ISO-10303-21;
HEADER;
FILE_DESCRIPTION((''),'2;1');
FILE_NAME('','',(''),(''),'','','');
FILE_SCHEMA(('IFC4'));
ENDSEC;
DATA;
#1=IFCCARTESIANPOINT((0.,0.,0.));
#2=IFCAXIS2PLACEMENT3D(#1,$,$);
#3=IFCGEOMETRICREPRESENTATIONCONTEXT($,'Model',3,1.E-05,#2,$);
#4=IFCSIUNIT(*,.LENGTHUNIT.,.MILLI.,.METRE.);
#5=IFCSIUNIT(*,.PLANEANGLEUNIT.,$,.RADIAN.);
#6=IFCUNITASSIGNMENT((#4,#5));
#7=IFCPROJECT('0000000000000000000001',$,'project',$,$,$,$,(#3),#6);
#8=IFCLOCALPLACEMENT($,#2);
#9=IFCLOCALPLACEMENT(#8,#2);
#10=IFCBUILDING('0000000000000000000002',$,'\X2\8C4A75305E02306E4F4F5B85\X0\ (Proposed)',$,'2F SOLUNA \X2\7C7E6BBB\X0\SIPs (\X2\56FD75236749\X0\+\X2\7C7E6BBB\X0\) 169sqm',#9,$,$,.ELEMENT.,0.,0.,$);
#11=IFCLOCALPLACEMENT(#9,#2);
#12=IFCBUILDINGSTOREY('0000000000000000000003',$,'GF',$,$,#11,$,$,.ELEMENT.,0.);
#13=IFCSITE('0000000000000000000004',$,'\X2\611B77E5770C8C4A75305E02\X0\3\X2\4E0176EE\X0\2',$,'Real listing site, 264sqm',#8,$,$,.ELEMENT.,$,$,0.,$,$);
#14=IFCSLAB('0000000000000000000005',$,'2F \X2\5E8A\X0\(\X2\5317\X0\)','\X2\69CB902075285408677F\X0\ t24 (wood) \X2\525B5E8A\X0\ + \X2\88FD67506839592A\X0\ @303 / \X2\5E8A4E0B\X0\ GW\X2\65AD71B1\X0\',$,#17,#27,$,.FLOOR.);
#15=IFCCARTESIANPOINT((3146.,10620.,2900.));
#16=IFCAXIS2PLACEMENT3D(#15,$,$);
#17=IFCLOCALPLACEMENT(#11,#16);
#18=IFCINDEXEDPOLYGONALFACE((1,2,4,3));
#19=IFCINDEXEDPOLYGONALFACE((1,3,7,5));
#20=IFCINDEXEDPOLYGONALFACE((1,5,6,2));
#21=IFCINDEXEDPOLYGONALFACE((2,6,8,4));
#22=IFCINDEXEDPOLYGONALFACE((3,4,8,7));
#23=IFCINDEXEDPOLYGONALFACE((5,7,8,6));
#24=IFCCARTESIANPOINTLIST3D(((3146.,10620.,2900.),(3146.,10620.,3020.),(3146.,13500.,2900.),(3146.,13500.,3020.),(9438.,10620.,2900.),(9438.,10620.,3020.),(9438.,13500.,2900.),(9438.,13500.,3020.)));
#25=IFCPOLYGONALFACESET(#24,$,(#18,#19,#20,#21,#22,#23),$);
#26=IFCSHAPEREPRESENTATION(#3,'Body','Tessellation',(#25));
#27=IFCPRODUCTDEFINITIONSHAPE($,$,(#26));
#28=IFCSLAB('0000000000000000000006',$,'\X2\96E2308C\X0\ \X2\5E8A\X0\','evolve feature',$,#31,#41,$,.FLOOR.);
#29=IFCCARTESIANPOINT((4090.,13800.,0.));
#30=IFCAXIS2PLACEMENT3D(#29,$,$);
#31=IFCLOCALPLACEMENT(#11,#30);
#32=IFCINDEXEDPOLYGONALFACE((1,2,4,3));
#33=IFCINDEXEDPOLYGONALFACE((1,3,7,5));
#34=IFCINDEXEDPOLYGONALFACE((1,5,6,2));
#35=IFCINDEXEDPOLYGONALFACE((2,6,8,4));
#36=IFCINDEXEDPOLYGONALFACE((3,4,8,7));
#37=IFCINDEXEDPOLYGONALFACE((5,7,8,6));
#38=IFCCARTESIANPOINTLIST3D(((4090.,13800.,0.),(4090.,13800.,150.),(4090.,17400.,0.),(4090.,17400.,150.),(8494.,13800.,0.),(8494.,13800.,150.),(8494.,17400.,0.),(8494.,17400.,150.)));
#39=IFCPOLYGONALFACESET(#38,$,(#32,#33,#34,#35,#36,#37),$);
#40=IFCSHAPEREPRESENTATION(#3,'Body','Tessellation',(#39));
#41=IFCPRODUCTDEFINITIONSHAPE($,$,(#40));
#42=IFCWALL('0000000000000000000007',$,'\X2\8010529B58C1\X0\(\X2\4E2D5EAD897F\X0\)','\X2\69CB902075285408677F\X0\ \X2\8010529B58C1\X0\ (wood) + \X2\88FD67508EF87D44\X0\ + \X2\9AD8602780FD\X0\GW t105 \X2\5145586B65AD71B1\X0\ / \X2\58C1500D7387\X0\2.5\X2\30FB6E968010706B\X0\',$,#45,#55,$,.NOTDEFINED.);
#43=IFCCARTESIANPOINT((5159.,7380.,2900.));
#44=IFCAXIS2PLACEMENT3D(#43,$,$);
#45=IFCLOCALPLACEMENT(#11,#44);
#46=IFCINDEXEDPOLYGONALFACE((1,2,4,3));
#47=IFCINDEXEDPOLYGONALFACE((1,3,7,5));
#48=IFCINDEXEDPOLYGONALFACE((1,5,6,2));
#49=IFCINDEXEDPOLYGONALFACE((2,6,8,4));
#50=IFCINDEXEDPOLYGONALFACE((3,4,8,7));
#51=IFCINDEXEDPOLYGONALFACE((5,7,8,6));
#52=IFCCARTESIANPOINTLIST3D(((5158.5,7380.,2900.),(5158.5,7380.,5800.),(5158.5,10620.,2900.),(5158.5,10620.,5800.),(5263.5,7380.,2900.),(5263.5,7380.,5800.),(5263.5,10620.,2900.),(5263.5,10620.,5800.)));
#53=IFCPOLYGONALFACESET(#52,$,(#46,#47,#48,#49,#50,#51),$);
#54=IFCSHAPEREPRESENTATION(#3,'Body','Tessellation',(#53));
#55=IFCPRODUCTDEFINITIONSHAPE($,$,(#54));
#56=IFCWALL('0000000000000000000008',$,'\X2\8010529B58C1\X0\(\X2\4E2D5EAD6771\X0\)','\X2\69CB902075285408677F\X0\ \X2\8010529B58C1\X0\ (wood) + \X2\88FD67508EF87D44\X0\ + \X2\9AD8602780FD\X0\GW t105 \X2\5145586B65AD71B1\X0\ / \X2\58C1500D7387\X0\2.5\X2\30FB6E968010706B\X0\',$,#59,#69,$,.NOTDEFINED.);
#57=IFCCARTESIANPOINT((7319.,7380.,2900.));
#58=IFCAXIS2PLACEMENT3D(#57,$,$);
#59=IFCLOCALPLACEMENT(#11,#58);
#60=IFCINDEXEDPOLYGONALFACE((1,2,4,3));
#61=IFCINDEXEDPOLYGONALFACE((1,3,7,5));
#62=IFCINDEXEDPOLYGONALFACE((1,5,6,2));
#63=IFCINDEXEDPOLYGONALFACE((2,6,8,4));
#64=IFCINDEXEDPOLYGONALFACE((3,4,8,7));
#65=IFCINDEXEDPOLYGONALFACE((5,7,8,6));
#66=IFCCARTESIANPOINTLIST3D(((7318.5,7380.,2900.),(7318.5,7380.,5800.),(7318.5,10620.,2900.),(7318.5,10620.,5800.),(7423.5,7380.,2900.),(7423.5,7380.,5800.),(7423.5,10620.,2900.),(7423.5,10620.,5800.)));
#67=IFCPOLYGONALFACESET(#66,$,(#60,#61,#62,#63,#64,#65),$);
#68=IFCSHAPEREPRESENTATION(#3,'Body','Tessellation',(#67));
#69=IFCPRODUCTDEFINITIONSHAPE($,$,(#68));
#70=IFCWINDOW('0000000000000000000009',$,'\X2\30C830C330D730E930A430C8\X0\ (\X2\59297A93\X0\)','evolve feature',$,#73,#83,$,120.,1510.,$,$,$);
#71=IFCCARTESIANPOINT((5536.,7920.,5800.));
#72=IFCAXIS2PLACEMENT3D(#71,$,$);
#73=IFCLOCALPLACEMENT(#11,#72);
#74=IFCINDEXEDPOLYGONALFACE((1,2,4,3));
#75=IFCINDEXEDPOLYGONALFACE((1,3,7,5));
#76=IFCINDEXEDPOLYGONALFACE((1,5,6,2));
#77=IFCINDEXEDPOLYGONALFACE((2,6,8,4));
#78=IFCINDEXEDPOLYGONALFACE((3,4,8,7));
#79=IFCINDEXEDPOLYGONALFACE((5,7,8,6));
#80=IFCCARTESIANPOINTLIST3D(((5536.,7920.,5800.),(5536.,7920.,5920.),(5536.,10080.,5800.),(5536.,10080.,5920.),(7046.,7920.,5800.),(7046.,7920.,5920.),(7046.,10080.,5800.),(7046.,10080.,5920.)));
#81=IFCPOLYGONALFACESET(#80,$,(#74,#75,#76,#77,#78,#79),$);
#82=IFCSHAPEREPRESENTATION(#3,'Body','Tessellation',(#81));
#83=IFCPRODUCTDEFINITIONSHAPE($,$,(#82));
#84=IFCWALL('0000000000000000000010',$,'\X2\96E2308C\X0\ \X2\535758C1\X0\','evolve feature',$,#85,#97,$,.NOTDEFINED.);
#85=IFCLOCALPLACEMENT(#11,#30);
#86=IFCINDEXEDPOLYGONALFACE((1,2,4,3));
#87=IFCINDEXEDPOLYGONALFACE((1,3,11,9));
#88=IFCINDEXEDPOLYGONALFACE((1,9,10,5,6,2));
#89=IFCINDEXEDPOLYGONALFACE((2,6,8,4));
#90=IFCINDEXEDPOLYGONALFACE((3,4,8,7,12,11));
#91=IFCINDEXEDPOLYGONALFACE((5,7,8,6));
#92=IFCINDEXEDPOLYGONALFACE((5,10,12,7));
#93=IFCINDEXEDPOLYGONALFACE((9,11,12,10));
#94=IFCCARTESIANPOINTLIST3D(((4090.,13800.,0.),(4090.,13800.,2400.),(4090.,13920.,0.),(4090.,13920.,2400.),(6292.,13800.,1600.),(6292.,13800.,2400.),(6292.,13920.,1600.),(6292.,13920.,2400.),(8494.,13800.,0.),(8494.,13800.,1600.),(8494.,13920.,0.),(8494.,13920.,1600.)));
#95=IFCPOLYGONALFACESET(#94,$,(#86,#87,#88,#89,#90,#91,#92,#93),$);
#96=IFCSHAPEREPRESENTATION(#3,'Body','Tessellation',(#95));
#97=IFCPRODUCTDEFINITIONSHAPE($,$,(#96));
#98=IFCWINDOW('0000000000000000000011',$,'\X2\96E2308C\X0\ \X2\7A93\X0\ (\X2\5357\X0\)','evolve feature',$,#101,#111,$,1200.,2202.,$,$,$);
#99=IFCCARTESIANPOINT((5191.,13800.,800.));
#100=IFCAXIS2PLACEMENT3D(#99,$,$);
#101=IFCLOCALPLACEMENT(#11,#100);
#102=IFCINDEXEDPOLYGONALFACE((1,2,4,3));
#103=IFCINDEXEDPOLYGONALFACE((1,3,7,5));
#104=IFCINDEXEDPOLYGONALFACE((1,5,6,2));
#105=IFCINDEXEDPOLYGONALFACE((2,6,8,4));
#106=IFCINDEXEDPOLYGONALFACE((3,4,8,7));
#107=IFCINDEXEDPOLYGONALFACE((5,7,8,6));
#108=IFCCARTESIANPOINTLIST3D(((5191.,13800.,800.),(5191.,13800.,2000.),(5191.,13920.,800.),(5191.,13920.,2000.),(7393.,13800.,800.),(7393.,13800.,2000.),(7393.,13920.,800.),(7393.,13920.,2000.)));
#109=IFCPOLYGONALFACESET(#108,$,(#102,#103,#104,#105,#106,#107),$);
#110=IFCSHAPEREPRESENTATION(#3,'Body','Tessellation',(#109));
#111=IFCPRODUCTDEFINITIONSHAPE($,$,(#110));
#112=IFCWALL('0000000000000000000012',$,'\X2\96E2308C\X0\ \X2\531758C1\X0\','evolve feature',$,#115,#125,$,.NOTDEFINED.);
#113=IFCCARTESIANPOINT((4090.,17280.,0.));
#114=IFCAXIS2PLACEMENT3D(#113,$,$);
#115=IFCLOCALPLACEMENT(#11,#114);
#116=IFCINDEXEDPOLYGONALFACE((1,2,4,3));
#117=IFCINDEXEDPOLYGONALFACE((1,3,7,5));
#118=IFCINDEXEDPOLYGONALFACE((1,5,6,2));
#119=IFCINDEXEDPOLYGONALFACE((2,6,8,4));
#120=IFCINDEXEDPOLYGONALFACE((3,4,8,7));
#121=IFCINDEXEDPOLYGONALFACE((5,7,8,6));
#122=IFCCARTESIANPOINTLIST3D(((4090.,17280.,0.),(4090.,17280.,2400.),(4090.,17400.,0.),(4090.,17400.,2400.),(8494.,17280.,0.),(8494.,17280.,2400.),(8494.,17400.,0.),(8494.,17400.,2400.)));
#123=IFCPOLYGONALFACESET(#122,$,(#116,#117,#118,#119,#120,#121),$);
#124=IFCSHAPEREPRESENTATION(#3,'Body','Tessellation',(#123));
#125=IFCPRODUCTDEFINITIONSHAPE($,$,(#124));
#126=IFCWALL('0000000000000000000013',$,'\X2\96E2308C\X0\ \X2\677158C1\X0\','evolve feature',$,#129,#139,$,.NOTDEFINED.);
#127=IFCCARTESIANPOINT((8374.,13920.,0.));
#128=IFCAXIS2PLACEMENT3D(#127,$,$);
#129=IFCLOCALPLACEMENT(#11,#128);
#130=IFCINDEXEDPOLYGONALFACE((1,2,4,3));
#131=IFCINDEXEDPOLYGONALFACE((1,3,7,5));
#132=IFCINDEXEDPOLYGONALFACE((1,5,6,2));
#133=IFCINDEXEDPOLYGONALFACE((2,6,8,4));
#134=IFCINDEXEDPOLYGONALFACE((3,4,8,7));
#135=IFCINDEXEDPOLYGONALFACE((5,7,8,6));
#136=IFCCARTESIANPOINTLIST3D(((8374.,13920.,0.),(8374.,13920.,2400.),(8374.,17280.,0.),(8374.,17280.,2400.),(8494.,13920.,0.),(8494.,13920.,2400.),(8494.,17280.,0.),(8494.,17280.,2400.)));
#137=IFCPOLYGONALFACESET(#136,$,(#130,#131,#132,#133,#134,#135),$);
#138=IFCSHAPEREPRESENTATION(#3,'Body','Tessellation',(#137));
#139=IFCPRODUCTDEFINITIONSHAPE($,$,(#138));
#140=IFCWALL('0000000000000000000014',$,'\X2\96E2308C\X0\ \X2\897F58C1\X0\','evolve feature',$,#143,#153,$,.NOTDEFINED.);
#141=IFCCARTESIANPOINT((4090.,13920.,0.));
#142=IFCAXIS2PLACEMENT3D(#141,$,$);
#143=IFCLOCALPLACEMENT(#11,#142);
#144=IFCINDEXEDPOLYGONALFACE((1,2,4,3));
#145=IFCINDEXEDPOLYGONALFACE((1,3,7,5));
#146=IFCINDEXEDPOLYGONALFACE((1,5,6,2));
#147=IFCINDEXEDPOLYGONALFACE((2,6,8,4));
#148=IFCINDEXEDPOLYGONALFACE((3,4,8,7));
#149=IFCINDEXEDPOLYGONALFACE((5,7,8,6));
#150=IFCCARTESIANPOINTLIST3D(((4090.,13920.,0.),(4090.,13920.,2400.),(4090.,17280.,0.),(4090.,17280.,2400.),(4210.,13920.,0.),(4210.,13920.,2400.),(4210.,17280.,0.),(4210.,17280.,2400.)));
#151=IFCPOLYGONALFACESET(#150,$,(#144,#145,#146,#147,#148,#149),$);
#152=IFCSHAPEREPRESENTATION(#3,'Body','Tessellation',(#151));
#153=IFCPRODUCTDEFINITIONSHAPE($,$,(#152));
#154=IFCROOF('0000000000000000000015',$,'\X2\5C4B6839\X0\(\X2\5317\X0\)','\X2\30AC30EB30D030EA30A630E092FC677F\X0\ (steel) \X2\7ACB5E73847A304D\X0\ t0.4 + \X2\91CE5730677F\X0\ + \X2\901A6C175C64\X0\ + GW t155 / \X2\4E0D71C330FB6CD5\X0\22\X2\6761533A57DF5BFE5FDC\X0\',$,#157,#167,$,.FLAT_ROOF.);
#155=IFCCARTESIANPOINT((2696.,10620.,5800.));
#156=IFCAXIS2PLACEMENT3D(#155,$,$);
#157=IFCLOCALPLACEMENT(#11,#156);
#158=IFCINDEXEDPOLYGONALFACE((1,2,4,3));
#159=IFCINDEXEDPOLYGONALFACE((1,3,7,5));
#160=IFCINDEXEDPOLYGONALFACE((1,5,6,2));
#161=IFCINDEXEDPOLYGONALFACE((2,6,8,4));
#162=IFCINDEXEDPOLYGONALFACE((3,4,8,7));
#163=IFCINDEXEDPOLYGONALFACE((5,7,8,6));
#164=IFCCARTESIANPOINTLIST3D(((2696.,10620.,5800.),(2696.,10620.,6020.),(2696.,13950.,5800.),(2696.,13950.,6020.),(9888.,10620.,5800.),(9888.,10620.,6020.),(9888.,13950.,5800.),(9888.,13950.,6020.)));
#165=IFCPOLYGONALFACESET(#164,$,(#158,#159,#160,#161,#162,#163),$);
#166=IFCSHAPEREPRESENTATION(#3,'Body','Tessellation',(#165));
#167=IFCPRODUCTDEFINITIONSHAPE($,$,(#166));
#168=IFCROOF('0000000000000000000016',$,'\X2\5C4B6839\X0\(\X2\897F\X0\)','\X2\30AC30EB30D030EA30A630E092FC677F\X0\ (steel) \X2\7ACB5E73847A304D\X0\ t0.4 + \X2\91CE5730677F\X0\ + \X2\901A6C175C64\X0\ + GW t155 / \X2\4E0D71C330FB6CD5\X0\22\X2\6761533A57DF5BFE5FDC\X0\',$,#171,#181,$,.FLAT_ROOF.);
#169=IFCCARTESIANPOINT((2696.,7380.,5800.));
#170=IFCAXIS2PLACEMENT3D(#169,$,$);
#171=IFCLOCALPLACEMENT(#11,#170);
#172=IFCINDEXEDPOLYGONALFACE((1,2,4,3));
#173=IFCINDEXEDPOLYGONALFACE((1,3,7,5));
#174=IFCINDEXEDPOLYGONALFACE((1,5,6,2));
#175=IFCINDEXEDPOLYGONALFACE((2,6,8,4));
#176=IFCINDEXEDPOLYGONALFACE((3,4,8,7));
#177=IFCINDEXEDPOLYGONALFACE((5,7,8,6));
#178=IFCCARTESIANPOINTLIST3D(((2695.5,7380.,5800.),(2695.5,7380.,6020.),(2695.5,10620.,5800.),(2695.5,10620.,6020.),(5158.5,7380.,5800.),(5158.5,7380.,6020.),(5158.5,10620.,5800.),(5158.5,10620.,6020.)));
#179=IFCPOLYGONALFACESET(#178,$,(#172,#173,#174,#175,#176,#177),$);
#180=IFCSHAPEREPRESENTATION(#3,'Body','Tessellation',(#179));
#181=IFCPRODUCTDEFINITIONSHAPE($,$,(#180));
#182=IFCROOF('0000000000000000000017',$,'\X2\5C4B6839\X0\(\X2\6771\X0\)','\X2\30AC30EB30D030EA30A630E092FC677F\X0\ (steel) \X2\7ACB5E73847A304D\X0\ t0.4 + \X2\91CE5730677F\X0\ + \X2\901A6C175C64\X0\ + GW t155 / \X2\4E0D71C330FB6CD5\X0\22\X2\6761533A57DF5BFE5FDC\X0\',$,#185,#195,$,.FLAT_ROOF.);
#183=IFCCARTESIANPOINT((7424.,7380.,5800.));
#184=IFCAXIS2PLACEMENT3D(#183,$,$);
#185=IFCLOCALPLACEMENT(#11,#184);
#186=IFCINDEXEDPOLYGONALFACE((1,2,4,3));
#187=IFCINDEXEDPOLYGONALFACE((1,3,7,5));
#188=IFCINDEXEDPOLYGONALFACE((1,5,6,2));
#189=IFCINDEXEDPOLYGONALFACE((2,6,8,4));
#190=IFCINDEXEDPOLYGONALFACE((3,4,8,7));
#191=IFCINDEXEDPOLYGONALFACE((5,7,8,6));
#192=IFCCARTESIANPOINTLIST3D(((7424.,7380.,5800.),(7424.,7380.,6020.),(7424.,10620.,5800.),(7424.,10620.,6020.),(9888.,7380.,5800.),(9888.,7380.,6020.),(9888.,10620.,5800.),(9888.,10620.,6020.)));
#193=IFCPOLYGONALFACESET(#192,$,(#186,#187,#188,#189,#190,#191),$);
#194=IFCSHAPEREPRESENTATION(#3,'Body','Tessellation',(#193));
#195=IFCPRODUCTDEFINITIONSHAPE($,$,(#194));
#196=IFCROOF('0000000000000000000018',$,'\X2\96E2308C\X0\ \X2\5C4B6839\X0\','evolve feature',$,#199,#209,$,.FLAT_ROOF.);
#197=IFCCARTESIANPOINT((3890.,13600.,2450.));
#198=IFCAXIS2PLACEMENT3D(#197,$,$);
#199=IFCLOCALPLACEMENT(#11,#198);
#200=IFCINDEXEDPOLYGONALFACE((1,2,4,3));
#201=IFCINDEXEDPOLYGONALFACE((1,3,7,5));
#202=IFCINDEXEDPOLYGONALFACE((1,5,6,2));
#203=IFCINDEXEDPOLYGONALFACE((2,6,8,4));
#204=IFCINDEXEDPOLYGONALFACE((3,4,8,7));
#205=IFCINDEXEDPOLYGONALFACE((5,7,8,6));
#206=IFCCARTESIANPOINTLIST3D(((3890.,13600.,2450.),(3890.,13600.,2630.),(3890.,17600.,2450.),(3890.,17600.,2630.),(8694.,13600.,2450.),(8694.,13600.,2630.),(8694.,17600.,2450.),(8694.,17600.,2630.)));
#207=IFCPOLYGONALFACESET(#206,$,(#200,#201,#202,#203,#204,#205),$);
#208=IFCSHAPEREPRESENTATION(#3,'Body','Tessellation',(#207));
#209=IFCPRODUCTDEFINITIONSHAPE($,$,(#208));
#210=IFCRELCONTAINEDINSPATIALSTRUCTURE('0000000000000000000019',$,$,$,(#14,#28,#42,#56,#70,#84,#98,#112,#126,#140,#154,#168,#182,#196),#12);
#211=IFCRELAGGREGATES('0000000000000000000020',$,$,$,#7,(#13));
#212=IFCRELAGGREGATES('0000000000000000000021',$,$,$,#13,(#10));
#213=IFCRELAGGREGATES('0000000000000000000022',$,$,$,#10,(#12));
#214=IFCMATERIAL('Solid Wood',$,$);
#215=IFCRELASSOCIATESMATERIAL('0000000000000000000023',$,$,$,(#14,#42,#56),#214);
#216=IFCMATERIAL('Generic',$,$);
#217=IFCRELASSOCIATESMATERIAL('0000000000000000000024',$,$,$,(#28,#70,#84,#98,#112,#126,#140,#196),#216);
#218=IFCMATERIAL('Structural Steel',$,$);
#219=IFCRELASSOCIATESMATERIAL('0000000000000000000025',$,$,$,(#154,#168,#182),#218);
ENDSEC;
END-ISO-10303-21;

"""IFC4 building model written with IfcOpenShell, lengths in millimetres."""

from ifc_helpers import new_model, si_unit, frame, frame_2d, origin, place, context, project, spatial, rectangle, extrude, material, element, fill, save


model = new_model("IFC4")

# Units and contexts
model_context = context("Model", 3, precision=1e-05, world=origin())
ifc_project = project(units=[si_unit("LENGTHUNIT", "METRE", prefix="MILLI"), si_unit("PLANEANGLEUNIT", "RADIAN")], contexts=[model_context])

# Site, building, storey
site_placement = place(None, origin())
site = spatial("IfcSite", under=ifc_project, at=site_placement, Name="愛知県豊田市3丁目2", ObjectType="Real listing site, 264sqm", CompositionType="ELEMENT", RefElevation=0.0)
building_placement = place(site_placement, origin())
building = spatial("IfcBuilding", under=site, at=building_placement, Name="豊田市の住宅 (Proposed)", ObjectType="2F SOLUNA 籾殻SIPs (国産杉+籾殻) 169sqm", CompositionType="ELEMENT", ElevationOfRefHeight=0.0, ElevationOfTerrain=0.0)
storey_placement = place(building_placement, origin())
storey = spatial("IfcBuildingStorey", under=building, at=storey_placement, Name="GF", CompositionType="ELEMENT", Elevation=0.0)

# Slabs
ifc_material_1 = material(Name="Solid Wood")
slab_1_placement = place(storey_placement, frame((3146.0, 10620.0, 2900.0)))
element("IfcSlab", 1, at=slab_1_placement, inside=storey, material=ifc_material_1, Name="2F 床(北)", Description="構造用合板 t24 (wood) 剛床 + 製材根太 @303 / 床下 GW断熱", PredefinedType="FLOOR", context=model_context, shape_type="SweptSolid", body=[
    extrude(rectangle(XDim=6292.0, YDim=2880.0, at=frame_2d((3146.0, 1440.0))), frame((3146.0, 10620.0, 2900.0)), (0.0, 0.0, 1.0), 120.0),
])
ifc_material_2 = material(Name="Generic")
slab_2_placement = place(storey_placement, frame((4090.0, 13800.0, 0.0)))
element("IfcSlab", 2, at=slab_2_placement, inside=storey, material=ifc_material_2, Name="離れ 床", Description="evolve feature", PredefinedType="FLOOR", context=model_context, shape_type="SweptSolid", body=[
    extrude(rectangle(XDim=4404.0, YDim=3600.0, at=frame_2d((2202.0, 1800.0))), frame((4090.0, 13800.0, 0.0)), (0.0, 0.0, 1.0), 150.0),
])

# Walls
wall_1_placement = place(storey_placement, frame((5159.0, 7380.0, 2900.0)))
element("IfcWall", 3, at=wall_1_placement, inside=storey, material=ifc_material_1, Name="耐力壁(中庭西)", Description="構造用合板 耐力壁 (wood) + 製材軸組 + 高性能GW t105 充填断熱 / 壁倍率2.5・準耐火", PredefinedType="NOTDEFINED", context=model_context, shape_type="SweptSolid", body=[
    extrude(rectangle(XDim=105.0, YDim=3240.0, at=frame_2d((52.0, 1620.0))), frame((5159.0, 7380.0, 2900.0)), (0.0, 0.0, 1.0), 2900.0),
])
wall_2_placement = place(storey_placement, frame((7319.0, 7380.0, 2900.0)))
element("IfcWall", 4, at=wall_2_placement, inside=storey, material=ifc_material_1, Name="耐力壁(中庭東)", Description="構造用合板 耐力壁 (wood) + 製材軸組 + 高性能GW t105 充填断熱 / 壁倍率2.5・準耐火", PredefinedType="NOTDEFINED", context=model_context, shape_type="SweptSolid", body=[
    extrude(rectangle(XDim=105.0, YDim=3240.0, at=frame_2d((52.0, 1620.0))), frame((7319.0, 7380.0, 2900.0)), (0.0, 0.0, 1.0), 2900.0),
])

# Window
window_1_placement = place(storey_placement, frame((5536.0, 7920.0, 5800.0)))
element("IfcWindow", 5, at=window_1_placement, inside=storey, material=ifc_material_2, Name="トップライト (天窓)", Description="evolve feature", OverallHeight=120.0, OverallWidth=1510.0, context=model_context, shape_type="SweptSolid", body=[
    extrude(rectangle(XDim=1510.0, YDim=2160.0, at=frame_2d((755.0, 1080.0))), frame((5536.0, 7920.0, 5800.0)), (0.0, 0.0, 1.0), 120.0),
])

# Wall, opening, window
wall_3_placement = place(storey_placement, frame((4090.0, 13800.0, 0.0)))
wall_3 = element("IfcWall", 6, at=wall_3_placement, inside=storey, material=ifc_material_2, Name="離れ 南壁", Description="evolve feature", PredefinedType="NOTDEFINED", context=model_context, shape_type="SweptSolid", body=[
    extrude(rectangle(XDim=4404.0, YDim=120.0, at=frame_2d((2202.0, 60.0))), frame((4090.0, 13800.0, 0.0)), (0.0, 0.0, 1.0), 2400.0),
])
opening_1_placement = place(storey_placement, frame((5191.0, 13800.0, 800.0)))
opening_1 = element("IfcOpeningElement", 7, at=opening_1_placement, cuts=wall_3, PredefinedType="NOTDEFINED", context=model_context, shape_type="SweptSolid", body=[
    extrude(rectangle(XDim=2202.0, YDim=120.0, at=frame_2d((1101.0, 60.0))), frame((5191.0, 13800.0, 800.0)), (0.0, 0.0, 1.0), 1200.0),
])
window_2_placement = place(storey_placement, frame((5191.0, 13800.0, 800.0)))
window_2 = element("IfcWindow", 8, at=window_2_placement, inside=storey, material=ifc_material_2, Name="離れ 窓 (南)", Description="evolve feature", OverallHeight=1200.0, OverallWidth=2202.0, context=model_context, shape_type="SweptSolid", body=[
    extrude(rectangle(XDim=2202.0, YDim=120.0, at=frame_2d((1101.0, 60.0))), frame((5191.0, 13800.0, 800.0)), (0.0, 0.0, 1.0), 1200.0),
])
fill(opening_1, window_2)

# Walls
wall_4_placement = place(storey_placement, frame((4090.0, 17280.0, 0.0)))
element("IfcWall", 9, at=wall_4_placement, inside=storey, material=ifc_material_2, Name="離れ 北壁", Description="evolve feature", PredefinedType="NOTDEFINED", context=model_context, shape_type="SweptSolid", body=[
    extrude(rectangle(XDim=4404.0, YDim=120.0, at=frame_2d((2202.0, 60.0))), frame((4090.0, 17280.0, 0.0)), (0.0, 0.0, 1.0), 2400.0),
])
wall_5_placement = place(storey_placement, frame((8374.0, 13920.0, 0.0)))
element("IfcWall", 10, at=wall_5_placement, inside=storey, material=ifc_material_2, Name="離れ 東壁", Description="evolve feature", PredefinedType="NOTDEFINED", context=model_context, shape_type="SweptSolid", body=[
    extrude(rectangle(XDim=120.0, YDim=3360.0, at=frame_2d((60.0, 1680.0))), frame((8374.0, 13920.0, 0.0)), (0.0, 0.0, 1.0), 2400.0),
])
wall_6_placement = place(storey_placement, frame((4090.0, 13920.0, 0.0)))
element("IfcWall", 11, at=wall_6_placement, inside=storey, material=ifc_material_2, Name="離れ 西壁", Description="evolve feature", PredefinedType="NOTDEFINED", context=model_context, shape_type="SweptSolid", body=[
    extrude(rectangle(XDim=120.0, YDim=3360.0, at=frame_2d((60.0, 1680.0))), frame((4090.0, 13920.0, 0.0)), (0.0, 0.0, 1.0), 2400.0),
])

# Roofs
ifc_material_3 = material(Name="Structural Steel")
for number, where, name in (
    (12, (2696.0, 10620.0, 5800.0), "屋根(北)"),
):
    element("IfcRoof", number, at=place(storey_placement, frame(where)), inside=storey, material=ifc_material_3, Name=name, Description="ガルバリウム鋼板 (steel) 立平葺き t0.4 + 野地板 + 通気層 + GW t155 / 不燃・法22条区域対応", PredefinedType="FLAT_ROOF", context=model_context, shape_type="SweptSolid", body=[
        extrude(rectangle(XDim=7192.0, YDim=3330.0, at=frame_2d((3596.0, 1665.0))), frame((2696.0, 10620.0, 5800.0)), (0.0, 0.0, 1.0), 220.0),
    ])
roof_1_placement = place(storey_placement, frame((2696.0, 7380.0, 5800.0)))
element("IfcRoof", 13, at=roof_1_placement, inside=storey, material=ifc_material_3, Name="屋根(西)", Description="ガルバリウム鋼板 (steel) 立平葺き t0.4 + 野地板 + 通気層 + GW t155 / 不燃・法22条区域対応", PredefinedType="FLAT_ROOF", context=model_context, shape_type="SweptSolid", body=[
    extrude(rectangle(XDim=2463.0, YDim=3240.0, at=frame_2d((1231.0, 1620.0))), frame((2696.0, 7380.0, 5800.0)), (0.0, 0.0, 1.0), 220.0),
])
roof_2_placement = place(storey_placement, frame((7424.0, 7380.0, 5800.0)))
element("IfcRoof", 14, at=roof_2_placement, inside=storey, material=ifc_material_3, Name="屋根(東)", Description="ガルバリウム鋼板 (steel) 立平葺き t0.4 + 野地板 + 通気層 + GW t155 / 不燃・法22条区域対応", PredefinedType="FLAT_ROOF", context=model_context, shape_type="SweptSolid", body=[
    extrude(rectangle(XDim=2464.0, YDim=3240.0, at=frame_2d((1232.0, 1620.0))), frame((7424.0, 7380.0, 5800.0)), (0.0, 0.0, 1.0), 220.0),
])
roof_3_placement = place(storey_placement, frame((3890.0, 13600.0, 2450.0)))
element("IfcRoof", 15, at=roof_3_placement, inside=storey, material=ifc_material_2, Name="離れ 屋根", Description="evolve feature", PredefinedType="FLAT_ROOF", context=model_context, shape_type="SweptSolid", body=[
    extrude(rectangle(XDim=4804.0, YDim=4000.0, at=frame_2d((2402.0, 2000.0))), frame((3890.0, 13600.0, 2450.0)), (0.0, 0.0, 1.0), 180.0),
])

save(model, "model.ifc")
